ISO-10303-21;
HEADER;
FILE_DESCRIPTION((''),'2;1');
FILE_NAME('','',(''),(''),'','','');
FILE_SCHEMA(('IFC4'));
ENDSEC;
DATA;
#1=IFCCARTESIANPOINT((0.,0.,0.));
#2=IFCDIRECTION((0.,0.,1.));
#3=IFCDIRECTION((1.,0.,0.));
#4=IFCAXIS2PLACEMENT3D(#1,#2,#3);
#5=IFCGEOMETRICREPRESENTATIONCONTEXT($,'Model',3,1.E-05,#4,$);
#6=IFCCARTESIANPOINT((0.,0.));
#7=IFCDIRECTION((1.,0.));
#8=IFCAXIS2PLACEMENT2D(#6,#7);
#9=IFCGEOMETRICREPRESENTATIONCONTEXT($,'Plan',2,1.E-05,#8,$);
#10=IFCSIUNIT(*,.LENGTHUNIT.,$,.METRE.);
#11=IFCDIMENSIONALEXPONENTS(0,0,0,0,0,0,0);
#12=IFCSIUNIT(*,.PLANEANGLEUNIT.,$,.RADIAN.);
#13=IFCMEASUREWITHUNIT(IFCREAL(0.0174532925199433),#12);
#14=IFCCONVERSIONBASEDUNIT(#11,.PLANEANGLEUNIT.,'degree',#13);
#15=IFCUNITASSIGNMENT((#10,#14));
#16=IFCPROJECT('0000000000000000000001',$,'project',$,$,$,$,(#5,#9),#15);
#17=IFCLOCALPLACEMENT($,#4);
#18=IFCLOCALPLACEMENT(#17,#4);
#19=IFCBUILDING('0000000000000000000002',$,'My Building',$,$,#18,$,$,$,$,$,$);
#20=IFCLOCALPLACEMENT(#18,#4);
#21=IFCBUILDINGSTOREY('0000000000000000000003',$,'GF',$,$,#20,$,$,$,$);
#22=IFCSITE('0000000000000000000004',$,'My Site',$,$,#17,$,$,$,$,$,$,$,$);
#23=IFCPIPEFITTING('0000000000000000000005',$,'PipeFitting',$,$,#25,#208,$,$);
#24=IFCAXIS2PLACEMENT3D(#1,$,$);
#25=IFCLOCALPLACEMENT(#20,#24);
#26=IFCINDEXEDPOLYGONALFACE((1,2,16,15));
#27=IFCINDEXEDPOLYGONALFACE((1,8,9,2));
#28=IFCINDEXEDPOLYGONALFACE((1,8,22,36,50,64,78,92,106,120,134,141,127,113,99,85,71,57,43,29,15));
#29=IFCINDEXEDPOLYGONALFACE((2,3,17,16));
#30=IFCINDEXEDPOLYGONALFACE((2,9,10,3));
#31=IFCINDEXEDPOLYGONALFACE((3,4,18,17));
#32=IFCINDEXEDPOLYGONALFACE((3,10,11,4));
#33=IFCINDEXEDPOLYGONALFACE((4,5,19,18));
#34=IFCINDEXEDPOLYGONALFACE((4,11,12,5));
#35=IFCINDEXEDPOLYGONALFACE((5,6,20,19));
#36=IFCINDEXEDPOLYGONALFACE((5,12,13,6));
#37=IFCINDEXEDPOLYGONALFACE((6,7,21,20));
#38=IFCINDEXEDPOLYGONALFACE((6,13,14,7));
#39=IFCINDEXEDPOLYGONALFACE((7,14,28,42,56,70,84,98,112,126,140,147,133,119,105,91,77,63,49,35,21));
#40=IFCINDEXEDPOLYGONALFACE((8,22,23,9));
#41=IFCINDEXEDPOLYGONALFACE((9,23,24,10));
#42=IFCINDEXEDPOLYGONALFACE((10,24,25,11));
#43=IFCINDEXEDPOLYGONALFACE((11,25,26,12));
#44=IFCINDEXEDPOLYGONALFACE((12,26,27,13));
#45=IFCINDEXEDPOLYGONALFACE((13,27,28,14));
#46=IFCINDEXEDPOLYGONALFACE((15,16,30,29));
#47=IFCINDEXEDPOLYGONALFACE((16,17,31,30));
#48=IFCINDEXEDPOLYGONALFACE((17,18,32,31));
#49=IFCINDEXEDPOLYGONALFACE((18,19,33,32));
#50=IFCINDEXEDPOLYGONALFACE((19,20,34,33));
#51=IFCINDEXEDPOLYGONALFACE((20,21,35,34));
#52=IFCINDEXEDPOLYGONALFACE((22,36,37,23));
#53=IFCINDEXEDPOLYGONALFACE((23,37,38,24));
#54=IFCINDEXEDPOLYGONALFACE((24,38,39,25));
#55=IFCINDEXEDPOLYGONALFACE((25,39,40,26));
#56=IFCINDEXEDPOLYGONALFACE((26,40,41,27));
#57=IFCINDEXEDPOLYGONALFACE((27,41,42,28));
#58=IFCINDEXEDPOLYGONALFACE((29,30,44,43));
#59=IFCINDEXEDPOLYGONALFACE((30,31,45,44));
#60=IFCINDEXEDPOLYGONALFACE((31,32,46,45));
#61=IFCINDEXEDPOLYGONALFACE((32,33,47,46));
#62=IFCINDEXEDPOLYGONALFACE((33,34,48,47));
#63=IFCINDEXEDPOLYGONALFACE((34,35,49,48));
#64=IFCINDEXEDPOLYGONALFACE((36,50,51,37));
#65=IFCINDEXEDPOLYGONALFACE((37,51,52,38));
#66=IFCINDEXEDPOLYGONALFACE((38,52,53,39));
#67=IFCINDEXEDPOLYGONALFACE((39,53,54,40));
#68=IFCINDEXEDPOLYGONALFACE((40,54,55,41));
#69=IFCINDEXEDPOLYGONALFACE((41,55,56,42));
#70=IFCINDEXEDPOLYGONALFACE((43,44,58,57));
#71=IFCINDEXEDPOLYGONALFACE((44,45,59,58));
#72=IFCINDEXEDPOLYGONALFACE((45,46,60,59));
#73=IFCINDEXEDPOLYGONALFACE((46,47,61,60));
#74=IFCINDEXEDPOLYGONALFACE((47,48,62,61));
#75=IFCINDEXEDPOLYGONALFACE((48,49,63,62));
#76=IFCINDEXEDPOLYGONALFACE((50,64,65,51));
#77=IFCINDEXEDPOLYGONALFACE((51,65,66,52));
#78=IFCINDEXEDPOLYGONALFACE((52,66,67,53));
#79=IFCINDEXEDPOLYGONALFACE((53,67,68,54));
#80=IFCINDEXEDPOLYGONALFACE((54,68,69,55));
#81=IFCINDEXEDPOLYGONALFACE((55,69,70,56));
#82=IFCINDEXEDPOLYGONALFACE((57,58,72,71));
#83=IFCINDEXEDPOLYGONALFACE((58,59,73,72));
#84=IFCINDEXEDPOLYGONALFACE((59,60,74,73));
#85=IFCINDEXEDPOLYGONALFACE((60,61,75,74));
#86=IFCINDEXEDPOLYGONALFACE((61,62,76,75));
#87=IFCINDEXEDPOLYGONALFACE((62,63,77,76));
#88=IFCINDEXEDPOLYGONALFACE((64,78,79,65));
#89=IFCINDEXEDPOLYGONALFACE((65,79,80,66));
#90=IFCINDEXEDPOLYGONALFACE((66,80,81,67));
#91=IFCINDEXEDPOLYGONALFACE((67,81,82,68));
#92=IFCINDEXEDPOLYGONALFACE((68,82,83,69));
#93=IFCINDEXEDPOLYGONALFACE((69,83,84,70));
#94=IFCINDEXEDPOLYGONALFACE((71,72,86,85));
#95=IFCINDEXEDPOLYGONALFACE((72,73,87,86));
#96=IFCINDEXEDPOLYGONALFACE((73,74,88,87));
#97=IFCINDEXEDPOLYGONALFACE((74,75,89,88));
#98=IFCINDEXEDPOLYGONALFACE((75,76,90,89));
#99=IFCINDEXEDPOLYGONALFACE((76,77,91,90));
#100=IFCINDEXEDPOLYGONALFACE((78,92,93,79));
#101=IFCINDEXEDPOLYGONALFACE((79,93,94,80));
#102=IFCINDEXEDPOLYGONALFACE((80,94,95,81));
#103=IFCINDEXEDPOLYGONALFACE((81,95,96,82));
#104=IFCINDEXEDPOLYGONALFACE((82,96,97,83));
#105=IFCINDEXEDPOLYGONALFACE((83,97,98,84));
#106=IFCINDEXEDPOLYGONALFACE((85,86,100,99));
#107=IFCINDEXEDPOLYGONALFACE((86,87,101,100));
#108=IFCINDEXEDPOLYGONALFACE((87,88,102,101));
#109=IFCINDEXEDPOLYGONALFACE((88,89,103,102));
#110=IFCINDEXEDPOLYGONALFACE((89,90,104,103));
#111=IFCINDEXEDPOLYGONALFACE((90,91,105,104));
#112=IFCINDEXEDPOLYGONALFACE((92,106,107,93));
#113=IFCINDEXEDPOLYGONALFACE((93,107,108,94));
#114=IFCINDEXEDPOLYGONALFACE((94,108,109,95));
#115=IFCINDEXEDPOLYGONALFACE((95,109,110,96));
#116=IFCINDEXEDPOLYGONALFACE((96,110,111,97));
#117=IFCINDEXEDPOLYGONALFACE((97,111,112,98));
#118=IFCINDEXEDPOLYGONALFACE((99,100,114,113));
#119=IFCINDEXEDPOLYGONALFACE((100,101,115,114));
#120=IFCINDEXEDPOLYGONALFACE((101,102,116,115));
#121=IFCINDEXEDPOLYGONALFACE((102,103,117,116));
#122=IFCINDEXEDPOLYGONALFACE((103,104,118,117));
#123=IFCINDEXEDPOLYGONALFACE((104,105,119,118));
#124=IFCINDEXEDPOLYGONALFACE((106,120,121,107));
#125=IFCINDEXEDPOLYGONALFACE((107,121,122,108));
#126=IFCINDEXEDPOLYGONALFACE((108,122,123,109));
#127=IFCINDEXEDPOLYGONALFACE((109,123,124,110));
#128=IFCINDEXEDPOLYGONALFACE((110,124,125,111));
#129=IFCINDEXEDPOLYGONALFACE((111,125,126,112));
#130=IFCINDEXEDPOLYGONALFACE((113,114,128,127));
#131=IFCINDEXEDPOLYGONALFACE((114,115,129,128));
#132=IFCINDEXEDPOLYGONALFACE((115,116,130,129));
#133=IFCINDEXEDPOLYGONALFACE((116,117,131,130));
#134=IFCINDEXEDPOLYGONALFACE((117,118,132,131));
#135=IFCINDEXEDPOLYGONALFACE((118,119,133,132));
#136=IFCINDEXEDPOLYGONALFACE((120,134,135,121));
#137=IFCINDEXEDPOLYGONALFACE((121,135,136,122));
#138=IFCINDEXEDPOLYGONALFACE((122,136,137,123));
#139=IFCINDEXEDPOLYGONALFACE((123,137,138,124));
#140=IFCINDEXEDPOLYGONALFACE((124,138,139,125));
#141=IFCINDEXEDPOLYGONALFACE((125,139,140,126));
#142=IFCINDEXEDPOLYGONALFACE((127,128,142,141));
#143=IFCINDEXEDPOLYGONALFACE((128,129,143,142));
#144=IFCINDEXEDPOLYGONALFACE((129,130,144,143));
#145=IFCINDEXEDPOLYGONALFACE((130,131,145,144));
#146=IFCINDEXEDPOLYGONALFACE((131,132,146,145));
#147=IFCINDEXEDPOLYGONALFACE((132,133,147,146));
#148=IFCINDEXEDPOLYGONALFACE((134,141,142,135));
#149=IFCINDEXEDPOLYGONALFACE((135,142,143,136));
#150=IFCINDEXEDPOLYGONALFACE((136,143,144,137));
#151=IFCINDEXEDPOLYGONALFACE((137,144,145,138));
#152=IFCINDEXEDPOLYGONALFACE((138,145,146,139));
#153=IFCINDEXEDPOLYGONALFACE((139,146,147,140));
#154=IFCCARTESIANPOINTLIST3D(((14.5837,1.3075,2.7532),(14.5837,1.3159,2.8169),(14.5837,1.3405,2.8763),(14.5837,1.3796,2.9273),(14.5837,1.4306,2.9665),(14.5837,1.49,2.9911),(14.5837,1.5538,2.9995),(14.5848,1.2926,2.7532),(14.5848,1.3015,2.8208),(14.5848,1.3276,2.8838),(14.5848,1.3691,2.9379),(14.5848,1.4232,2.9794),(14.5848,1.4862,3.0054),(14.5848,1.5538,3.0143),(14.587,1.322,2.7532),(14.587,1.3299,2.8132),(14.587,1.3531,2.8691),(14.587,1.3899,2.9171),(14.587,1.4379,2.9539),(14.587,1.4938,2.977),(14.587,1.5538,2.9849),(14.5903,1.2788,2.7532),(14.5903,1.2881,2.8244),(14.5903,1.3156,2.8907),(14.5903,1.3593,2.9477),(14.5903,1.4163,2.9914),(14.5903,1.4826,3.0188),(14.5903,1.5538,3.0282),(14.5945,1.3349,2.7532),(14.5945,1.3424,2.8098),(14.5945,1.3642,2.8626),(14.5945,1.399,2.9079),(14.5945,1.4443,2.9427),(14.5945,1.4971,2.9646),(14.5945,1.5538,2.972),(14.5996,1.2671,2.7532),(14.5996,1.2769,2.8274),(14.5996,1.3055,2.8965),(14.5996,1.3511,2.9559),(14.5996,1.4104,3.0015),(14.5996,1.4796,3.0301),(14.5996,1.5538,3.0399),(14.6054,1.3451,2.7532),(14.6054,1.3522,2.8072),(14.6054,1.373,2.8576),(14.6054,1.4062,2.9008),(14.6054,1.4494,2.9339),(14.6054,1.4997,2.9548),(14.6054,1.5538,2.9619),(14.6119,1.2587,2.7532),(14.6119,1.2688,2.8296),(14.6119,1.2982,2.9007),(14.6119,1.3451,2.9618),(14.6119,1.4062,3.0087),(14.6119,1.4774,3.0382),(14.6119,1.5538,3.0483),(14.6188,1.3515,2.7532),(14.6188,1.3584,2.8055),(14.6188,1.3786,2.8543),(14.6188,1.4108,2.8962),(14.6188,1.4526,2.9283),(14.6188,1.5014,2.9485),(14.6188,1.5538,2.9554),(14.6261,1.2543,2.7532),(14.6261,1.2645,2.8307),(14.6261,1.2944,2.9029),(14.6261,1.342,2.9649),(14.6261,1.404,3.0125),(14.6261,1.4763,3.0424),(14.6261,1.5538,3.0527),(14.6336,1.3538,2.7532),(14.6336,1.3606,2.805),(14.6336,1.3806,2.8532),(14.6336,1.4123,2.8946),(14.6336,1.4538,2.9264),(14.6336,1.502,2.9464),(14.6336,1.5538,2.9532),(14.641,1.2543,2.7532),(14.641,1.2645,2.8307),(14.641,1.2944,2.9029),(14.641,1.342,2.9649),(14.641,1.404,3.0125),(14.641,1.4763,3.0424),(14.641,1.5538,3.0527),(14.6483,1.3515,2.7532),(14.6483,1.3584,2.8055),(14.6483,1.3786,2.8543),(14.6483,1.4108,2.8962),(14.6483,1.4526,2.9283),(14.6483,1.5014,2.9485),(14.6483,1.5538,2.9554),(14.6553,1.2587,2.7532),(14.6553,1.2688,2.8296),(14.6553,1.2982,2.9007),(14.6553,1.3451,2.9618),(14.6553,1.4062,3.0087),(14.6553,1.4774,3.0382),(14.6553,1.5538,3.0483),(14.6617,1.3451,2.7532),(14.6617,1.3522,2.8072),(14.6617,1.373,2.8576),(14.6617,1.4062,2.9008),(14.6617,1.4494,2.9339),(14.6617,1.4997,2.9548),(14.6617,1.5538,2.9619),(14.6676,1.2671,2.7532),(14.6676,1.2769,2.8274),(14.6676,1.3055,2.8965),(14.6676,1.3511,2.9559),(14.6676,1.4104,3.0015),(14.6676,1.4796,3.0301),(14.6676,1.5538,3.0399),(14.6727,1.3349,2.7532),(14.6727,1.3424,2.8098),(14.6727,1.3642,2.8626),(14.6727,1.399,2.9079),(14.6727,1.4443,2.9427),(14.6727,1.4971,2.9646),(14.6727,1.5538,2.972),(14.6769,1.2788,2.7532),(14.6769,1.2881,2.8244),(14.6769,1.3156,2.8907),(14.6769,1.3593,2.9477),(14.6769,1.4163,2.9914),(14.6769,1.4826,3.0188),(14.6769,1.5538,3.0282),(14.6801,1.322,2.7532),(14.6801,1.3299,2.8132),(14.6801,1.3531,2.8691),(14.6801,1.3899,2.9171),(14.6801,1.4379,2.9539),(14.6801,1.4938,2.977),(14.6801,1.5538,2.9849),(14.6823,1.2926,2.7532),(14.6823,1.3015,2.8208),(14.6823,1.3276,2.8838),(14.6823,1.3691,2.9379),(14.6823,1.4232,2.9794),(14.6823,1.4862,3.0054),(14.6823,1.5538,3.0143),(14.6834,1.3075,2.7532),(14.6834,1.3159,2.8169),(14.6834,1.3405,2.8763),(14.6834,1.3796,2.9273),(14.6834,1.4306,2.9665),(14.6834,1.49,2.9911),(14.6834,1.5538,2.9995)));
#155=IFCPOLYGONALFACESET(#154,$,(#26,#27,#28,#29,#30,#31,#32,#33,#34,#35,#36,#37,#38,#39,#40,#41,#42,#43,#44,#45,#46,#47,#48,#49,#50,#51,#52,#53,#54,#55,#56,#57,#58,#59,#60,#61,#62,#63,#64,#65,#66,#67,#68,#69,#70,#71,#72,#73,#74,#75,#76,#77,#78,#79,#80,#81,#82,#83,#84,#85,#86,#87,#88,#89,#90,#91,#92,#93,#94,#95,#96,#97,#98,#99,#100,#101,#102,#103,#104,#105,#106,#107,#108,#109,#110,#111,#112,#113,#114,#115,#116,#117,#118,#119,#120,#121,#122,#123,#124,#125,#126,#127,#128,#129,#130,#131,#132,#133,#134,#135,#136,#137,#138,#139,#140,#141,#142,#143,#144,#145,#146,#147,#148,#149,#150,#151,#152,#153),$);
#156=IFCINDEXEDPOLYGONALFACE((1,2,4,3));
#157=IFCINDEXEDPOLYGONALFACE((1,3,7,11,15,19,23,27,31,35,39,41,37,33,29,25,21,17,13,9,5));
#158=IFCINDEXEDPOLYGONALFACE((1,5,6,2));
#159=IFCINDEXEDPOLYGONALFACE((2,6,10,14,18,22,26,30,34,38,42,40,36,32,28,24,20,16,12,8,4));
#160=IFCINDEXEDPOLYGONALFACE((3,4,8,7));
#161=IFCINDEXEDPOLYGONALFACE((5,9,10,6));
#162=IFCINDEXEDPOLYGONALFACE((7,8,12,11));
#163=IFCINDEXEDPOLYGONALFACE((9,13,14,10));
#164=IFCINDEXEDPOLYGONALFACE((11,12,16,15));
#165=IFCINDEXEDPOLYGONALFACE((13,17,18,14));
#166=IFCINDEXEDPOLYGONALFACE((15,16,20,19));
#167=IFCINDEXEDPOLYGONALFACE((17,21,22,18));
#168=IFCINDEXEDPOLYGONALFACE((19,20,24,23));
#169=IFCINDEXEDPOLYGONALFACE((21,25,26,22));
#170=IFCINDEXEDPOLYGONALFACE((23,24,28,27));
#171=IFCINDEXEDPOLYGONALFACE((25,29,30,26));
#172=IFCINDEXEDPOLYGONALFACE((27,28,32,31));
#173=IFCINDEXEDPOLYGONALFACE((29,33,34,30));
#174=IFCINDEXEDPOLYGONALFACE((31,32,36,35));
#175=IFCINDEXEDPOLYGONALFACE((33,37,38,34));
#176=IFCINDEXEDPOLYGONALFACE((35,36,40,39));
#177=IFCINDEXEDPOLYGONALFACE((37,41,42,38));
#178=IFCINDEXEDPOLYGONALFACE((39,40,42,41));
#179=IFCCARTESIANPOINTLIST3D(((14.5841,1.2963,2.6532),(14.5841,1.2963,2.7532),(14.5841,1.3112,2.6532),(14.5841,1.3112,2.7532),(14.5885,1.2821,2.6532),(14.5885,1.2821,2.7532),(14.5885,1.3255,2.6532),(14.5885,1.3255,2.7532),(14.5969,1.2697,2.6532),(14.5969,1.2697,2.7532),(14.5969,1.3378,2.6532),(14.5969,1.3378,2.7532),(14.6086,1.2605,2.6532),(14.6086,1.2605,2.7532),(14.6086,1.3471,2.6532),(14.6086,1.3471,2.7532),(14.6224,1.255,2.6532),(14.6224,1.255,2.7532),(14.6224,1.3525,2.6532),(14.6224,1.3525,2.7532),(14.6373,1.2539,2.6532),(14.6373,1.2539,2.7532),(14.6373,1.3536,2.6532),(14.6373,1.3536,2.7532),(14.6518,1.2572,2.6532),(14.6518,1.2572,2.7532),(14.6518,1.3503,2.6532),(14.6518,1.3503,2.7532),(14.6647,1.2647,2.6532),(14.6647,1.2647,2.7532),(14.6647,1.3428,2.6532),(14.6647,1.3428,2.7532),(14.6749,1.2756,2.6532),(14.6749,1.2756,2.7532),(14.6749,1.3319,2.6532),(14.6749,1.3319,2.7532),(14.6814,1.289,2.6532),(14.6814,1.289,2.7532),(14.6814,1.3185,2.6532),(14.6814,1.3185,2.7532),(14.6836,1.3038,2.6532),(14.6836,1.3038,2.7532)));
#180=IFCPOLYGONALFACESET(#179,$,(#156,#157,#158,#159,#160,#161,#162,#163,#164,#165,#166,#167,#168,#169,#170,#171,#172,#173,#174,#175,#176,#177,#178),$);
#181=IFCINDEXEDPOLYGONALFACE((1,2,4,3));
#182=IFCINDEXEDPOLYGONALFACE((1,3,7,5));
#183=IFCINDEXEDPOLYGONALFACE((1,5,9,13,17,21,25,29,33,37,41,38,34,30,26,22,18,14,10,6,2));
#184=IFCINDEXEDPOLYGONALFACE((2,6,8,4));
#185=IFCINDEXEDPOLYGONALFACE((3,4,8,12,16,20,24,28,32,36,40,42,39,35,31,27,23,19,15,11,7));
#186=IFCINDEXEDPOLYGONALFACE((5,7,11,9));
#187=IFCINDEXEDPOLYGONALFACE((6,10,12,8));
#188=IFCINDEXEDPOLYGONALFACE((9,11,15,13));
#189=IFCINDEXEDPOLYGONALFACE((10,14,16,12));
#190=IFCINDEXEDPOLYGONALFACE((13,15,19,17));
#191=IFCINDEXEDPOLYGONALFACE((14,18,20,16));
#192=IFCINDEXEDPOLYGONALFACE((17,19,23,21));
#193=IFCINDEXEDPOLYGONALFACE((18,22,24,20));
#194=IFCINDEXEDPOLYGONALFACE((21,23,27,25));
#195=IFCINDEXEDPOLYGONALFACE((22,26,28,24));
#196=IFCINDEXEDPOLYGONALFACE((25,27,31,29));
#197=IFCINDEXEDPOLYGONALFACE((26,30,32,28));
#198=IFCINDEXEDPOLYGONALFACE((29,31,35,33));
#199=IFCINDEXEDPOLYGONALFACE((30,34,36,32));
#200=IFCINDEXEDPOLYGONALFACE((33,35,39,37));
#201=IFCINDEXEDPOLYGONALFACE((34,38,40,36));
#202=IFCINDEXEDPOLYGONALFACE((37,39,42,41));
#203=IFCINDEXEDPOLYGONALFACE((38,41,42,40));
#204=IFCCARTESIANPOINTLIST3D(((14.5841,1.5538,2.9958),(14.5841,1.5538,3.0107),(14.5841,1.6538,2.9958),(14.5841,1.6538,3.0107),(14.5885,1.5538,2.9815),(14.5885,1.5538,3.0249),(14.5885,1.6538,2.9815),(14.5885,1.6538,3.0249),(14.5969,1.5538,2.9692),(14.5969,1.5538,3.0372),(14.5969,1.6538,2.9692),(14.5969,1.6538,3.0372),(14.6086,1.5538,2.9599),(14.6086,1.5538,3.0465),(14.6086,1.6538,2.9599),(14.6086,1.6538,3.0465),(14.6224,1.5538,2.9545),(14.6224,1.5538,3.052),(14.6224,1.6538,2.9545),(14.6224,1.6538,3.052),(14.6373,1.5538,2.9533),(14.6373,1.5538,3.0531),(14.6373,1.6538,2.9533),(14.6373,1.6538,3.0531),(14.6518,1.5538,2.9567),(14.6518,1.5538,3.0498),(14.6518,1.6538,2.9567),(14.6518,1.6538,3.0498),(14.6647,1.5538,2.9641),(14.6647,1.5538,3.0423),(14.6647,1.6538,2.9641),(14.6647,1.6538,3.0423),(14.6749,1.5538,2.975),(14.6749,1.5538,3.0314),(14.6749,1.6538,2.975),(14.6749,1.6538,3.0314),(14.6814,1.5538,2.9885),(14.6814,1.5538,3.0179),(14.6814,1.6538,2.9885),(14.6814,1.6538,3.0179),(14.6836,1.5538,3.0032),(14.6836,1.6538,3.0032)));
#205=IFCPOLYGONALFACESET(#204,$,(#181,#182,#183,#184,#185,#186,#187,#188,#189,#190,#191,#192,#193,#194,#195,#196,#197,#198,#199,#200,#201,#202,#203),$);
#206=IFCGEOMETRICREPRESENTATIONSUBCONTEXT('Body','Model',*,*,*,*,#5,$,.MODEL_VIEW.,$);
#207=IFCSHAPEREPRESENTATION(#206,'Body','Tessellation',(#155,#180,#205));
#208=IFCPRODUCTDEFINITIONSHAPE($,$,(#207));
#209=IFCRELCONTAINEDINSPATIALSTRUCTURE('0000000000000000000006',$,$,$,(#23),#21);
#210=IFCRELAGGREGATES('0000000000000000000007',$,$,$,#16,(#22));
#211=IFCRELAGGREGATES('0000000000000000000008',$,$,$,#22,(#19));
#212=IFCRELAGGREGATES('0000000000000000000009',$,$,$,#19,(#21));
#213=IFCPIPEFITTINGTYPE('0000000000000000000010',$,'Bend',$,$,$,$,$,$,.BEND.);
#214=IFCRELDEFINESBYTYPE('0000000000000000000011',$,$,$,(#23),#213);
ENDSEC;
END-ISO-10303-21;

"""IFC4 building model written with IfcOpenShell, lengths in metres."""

from ifc_helpers import new_model, entity, si_unit, converted_unit, frame, origin_with_axes, origin_2d_with_axis, place, context, subcontext, project, spatial, circle, extrude, source, transform, mapped, type_object, type_shapes, element, save


model = new_model("IFC4")

# Units and contexts
model_context = context("Model", 3, precision=1e-05, world=origin_with_axes())
plan_context = context("Plan", 2, precision=1e-05, world=origin_2d_with_axis())
body_context_1 = subcontext(model_context, "Body", "Model", "MODEL_VIEW")
ifc_project = project(units=[si_unit("LENGTHUNIT", "METRE"), converted_unit("PLANEANGLEUNIT", "degree", entity("IfcReal", 0.0174532925199433), si_unit("PLANEANGLEUNIT", "RADIAN"), dimensions=[0, 0, 0, 0, 0, 0, 0])], contexts=[model_context, plan_context])

# Site, building, storey
site_placement = place(None, origin_with_axes())
site = spatial("IfcSite", under=ifc_project, at=site_placement, Name="My Site")
building_placement = place(site_placement, origin_with_axes())
building = spatial("IfcBuilding", under=site, at=building_placement, Name="My Building")
storey_placement = place(building_placement, origin_with_axes())
storey = spatial("IfcBuildingStorey", under=building, at=storey_placement, Name="GF")

# Pipe fitting
pipe_fitting_type = type_object("IfcPipeFittingType", Name="Bend", PredefinedType="BEND")
shared_shape_1 = source(origin_with_axes(), body_context_1, "Body", "SolidModel", [
    entity("IfcSweptDiskSolid", entity("IfcIndexedPolyCurve", entity("IfcCartesianPointList3D", [[0.0, 0.0, -0.1], [0.0, -0.0732, -0.2768], [0.0, -0.25, -0.35]]), [entity("IfcArcIndex", [1, 2, 3])]), 0.05),
    extrude(circle(Radius=0.05), origin_with_axes(), (0.0, 0.0, -1.0), 0.1),
    extrude(circle(Radius=0.05), frame((0.0, -0.25, -0.35), z_axis=(0.0, -1.0, 0.0), x_axis=(1.0, 0.0, 0.0)), (0.0, 0.0, 1.0), 0.1),
])
type_shapes(pipe_fitting_type, [shared_shape_1])
for number, where, z_axis, x_axis, name in (
    (1, (14.6336, 1.3038, 2.6532), (0.0, 0.0, -1.0), (1.0, 0.0, 0.0), "PipeFitting"),
):
    element("IfcPipeFitting", number, at=place(storey_placement, frame(where, z_axis=z_axis, x_axis=x_axis)), inside=storey, type_object=pipe_fitting_type, Name=name, context=body_context_1, shape_type="MappedRepresentation", body=[
        mapped(shared_shape_1, transform((0.0, 0.0, 0.0), x_axis=(1.0, 0.0, 0.0), y_axis=(0.0, 1.0, 0.0), z_axis=(0.0, 0.0, 1.0), scale=1.0)),
    ])

save(model, "model.ifc")
